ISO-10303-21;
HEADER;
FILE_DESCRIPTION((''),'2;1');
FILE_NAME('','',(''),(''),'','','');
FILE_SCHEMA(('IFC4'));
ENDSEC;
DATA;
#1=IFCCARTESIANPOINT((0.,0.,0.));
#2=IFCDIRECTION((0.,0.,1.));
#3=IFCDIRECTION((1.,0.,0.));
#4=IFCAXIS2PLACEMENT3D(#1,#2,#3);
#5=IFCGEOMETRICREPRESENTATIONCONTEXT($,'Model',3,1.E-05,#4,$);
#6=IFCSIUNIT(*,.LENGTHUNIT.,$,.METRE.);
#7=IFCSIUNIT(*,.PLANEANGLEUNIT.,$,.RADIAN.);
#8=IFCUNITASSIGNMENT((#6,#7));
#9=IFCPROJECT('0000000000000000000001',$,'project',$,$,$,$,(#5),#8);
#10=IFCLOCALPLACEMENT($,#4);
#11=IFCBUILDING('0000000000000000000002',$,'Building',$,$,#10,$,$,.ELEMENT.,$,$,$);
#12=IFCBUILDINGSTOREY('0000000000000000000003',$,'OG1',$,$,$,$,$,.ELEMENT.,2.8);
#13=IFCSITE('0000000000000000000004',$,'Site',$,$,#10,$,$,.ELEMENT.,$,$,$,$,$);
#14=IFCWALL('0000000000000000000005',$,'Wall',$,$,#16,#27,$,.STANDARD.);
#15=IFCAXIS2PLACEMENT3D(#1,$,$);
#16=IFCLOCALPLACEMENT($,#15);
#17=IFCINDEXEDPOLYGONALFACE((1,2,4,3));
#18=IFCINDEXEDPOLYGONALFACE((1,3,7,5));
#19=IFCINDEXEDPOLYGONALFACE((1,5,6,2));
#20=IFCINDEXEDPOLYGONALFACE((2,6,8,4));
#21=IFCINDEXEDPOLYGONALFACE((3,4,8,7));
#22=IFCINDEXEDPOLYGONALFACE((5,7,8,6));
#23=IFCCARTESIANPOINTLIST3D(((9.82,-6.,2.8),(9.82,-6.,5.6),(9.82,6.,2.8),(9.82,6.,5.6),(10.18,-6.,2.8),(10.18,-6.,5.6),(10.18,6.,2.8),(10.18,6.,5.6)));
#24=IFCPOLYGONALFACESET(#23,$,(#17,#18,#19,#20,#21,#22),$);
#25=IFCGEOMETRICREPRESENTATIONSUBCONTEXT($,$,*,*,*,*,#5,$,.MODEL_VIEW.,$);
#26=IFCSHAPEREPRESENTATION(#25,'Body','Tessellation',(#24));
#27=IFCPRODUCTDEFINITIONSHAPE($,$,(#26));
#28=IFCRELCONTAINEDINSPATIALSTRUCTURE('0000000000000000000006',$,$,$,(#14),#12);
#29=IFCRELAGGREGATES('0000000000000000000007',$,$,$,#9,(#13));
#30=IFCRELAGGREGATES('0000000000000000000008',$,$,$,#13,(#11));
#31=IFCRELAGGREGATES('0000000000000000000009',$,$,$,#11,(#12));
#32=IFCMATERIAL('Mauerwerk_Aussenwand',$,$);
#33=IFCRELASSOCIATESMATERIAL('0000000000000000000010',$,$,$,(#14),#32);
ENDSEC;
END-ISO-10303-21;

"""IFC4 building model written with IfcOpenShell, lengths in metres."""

from ifc_helpers import new_model, si_unit, frame, frame_2d, origin, origin_with_axes, place, context, subcontext, project, spatial, rectangle, extrude, material, element, save


model = new_model("IFC4")

# Units and contexts
model_context = context("Model", 3, precision=1e-05, world=origin_with_axes())
sub_context = subcontext(model_context, None, None, "MODEL_VIEW")
ifc_project = project(units=[si_unit("LENGTHUNIT", "METRE"), si_unit("PLANEANGLEUNIT", "RADIAN")], contexts=[model_context])

# Site, building, storey
placement_1 = place(None, origin_with_axes())
site = spatial("IfcSite", under=ifc_project, at=placement_1, Name="Site", CompositionType="ELEMENT")
building = spatial("IfcBuilding", under=site, at=placement_1, Name="Building", CompositionType="ELEMENT")
storey = spatial("IfcBuildingStorey", under=building, Name="OG1", CompositionType="ELEMENT", Elevation=2.8)

# Wall
ifc_material = material(Name="Mauerwerk_Aussenwand")
placement_2 = place(None, origin_with_axes())
placement_3 = place(placement_2, frame((0.0, 0.0, 2.8)))
wall_placement = place(placement_3, frame((10.0, -6.0, 0.0), x_axis=(0.0, 1.0, 0.0)))
element("IfcWall", 1, at=wall_placement, inside=storey, material=ifc_material, Name="Wall", PredefinedType="STANDARD", context=sub_context, shape_type="SweptSolid", body=[
    extrude(rectangle(XDim=12.0, YDim=0.36, at=frame_2d((6.0, 0.0))), origin(), (0.0, 0.0, 1.0), 2.8),
])

save(model, "model.ifc")
